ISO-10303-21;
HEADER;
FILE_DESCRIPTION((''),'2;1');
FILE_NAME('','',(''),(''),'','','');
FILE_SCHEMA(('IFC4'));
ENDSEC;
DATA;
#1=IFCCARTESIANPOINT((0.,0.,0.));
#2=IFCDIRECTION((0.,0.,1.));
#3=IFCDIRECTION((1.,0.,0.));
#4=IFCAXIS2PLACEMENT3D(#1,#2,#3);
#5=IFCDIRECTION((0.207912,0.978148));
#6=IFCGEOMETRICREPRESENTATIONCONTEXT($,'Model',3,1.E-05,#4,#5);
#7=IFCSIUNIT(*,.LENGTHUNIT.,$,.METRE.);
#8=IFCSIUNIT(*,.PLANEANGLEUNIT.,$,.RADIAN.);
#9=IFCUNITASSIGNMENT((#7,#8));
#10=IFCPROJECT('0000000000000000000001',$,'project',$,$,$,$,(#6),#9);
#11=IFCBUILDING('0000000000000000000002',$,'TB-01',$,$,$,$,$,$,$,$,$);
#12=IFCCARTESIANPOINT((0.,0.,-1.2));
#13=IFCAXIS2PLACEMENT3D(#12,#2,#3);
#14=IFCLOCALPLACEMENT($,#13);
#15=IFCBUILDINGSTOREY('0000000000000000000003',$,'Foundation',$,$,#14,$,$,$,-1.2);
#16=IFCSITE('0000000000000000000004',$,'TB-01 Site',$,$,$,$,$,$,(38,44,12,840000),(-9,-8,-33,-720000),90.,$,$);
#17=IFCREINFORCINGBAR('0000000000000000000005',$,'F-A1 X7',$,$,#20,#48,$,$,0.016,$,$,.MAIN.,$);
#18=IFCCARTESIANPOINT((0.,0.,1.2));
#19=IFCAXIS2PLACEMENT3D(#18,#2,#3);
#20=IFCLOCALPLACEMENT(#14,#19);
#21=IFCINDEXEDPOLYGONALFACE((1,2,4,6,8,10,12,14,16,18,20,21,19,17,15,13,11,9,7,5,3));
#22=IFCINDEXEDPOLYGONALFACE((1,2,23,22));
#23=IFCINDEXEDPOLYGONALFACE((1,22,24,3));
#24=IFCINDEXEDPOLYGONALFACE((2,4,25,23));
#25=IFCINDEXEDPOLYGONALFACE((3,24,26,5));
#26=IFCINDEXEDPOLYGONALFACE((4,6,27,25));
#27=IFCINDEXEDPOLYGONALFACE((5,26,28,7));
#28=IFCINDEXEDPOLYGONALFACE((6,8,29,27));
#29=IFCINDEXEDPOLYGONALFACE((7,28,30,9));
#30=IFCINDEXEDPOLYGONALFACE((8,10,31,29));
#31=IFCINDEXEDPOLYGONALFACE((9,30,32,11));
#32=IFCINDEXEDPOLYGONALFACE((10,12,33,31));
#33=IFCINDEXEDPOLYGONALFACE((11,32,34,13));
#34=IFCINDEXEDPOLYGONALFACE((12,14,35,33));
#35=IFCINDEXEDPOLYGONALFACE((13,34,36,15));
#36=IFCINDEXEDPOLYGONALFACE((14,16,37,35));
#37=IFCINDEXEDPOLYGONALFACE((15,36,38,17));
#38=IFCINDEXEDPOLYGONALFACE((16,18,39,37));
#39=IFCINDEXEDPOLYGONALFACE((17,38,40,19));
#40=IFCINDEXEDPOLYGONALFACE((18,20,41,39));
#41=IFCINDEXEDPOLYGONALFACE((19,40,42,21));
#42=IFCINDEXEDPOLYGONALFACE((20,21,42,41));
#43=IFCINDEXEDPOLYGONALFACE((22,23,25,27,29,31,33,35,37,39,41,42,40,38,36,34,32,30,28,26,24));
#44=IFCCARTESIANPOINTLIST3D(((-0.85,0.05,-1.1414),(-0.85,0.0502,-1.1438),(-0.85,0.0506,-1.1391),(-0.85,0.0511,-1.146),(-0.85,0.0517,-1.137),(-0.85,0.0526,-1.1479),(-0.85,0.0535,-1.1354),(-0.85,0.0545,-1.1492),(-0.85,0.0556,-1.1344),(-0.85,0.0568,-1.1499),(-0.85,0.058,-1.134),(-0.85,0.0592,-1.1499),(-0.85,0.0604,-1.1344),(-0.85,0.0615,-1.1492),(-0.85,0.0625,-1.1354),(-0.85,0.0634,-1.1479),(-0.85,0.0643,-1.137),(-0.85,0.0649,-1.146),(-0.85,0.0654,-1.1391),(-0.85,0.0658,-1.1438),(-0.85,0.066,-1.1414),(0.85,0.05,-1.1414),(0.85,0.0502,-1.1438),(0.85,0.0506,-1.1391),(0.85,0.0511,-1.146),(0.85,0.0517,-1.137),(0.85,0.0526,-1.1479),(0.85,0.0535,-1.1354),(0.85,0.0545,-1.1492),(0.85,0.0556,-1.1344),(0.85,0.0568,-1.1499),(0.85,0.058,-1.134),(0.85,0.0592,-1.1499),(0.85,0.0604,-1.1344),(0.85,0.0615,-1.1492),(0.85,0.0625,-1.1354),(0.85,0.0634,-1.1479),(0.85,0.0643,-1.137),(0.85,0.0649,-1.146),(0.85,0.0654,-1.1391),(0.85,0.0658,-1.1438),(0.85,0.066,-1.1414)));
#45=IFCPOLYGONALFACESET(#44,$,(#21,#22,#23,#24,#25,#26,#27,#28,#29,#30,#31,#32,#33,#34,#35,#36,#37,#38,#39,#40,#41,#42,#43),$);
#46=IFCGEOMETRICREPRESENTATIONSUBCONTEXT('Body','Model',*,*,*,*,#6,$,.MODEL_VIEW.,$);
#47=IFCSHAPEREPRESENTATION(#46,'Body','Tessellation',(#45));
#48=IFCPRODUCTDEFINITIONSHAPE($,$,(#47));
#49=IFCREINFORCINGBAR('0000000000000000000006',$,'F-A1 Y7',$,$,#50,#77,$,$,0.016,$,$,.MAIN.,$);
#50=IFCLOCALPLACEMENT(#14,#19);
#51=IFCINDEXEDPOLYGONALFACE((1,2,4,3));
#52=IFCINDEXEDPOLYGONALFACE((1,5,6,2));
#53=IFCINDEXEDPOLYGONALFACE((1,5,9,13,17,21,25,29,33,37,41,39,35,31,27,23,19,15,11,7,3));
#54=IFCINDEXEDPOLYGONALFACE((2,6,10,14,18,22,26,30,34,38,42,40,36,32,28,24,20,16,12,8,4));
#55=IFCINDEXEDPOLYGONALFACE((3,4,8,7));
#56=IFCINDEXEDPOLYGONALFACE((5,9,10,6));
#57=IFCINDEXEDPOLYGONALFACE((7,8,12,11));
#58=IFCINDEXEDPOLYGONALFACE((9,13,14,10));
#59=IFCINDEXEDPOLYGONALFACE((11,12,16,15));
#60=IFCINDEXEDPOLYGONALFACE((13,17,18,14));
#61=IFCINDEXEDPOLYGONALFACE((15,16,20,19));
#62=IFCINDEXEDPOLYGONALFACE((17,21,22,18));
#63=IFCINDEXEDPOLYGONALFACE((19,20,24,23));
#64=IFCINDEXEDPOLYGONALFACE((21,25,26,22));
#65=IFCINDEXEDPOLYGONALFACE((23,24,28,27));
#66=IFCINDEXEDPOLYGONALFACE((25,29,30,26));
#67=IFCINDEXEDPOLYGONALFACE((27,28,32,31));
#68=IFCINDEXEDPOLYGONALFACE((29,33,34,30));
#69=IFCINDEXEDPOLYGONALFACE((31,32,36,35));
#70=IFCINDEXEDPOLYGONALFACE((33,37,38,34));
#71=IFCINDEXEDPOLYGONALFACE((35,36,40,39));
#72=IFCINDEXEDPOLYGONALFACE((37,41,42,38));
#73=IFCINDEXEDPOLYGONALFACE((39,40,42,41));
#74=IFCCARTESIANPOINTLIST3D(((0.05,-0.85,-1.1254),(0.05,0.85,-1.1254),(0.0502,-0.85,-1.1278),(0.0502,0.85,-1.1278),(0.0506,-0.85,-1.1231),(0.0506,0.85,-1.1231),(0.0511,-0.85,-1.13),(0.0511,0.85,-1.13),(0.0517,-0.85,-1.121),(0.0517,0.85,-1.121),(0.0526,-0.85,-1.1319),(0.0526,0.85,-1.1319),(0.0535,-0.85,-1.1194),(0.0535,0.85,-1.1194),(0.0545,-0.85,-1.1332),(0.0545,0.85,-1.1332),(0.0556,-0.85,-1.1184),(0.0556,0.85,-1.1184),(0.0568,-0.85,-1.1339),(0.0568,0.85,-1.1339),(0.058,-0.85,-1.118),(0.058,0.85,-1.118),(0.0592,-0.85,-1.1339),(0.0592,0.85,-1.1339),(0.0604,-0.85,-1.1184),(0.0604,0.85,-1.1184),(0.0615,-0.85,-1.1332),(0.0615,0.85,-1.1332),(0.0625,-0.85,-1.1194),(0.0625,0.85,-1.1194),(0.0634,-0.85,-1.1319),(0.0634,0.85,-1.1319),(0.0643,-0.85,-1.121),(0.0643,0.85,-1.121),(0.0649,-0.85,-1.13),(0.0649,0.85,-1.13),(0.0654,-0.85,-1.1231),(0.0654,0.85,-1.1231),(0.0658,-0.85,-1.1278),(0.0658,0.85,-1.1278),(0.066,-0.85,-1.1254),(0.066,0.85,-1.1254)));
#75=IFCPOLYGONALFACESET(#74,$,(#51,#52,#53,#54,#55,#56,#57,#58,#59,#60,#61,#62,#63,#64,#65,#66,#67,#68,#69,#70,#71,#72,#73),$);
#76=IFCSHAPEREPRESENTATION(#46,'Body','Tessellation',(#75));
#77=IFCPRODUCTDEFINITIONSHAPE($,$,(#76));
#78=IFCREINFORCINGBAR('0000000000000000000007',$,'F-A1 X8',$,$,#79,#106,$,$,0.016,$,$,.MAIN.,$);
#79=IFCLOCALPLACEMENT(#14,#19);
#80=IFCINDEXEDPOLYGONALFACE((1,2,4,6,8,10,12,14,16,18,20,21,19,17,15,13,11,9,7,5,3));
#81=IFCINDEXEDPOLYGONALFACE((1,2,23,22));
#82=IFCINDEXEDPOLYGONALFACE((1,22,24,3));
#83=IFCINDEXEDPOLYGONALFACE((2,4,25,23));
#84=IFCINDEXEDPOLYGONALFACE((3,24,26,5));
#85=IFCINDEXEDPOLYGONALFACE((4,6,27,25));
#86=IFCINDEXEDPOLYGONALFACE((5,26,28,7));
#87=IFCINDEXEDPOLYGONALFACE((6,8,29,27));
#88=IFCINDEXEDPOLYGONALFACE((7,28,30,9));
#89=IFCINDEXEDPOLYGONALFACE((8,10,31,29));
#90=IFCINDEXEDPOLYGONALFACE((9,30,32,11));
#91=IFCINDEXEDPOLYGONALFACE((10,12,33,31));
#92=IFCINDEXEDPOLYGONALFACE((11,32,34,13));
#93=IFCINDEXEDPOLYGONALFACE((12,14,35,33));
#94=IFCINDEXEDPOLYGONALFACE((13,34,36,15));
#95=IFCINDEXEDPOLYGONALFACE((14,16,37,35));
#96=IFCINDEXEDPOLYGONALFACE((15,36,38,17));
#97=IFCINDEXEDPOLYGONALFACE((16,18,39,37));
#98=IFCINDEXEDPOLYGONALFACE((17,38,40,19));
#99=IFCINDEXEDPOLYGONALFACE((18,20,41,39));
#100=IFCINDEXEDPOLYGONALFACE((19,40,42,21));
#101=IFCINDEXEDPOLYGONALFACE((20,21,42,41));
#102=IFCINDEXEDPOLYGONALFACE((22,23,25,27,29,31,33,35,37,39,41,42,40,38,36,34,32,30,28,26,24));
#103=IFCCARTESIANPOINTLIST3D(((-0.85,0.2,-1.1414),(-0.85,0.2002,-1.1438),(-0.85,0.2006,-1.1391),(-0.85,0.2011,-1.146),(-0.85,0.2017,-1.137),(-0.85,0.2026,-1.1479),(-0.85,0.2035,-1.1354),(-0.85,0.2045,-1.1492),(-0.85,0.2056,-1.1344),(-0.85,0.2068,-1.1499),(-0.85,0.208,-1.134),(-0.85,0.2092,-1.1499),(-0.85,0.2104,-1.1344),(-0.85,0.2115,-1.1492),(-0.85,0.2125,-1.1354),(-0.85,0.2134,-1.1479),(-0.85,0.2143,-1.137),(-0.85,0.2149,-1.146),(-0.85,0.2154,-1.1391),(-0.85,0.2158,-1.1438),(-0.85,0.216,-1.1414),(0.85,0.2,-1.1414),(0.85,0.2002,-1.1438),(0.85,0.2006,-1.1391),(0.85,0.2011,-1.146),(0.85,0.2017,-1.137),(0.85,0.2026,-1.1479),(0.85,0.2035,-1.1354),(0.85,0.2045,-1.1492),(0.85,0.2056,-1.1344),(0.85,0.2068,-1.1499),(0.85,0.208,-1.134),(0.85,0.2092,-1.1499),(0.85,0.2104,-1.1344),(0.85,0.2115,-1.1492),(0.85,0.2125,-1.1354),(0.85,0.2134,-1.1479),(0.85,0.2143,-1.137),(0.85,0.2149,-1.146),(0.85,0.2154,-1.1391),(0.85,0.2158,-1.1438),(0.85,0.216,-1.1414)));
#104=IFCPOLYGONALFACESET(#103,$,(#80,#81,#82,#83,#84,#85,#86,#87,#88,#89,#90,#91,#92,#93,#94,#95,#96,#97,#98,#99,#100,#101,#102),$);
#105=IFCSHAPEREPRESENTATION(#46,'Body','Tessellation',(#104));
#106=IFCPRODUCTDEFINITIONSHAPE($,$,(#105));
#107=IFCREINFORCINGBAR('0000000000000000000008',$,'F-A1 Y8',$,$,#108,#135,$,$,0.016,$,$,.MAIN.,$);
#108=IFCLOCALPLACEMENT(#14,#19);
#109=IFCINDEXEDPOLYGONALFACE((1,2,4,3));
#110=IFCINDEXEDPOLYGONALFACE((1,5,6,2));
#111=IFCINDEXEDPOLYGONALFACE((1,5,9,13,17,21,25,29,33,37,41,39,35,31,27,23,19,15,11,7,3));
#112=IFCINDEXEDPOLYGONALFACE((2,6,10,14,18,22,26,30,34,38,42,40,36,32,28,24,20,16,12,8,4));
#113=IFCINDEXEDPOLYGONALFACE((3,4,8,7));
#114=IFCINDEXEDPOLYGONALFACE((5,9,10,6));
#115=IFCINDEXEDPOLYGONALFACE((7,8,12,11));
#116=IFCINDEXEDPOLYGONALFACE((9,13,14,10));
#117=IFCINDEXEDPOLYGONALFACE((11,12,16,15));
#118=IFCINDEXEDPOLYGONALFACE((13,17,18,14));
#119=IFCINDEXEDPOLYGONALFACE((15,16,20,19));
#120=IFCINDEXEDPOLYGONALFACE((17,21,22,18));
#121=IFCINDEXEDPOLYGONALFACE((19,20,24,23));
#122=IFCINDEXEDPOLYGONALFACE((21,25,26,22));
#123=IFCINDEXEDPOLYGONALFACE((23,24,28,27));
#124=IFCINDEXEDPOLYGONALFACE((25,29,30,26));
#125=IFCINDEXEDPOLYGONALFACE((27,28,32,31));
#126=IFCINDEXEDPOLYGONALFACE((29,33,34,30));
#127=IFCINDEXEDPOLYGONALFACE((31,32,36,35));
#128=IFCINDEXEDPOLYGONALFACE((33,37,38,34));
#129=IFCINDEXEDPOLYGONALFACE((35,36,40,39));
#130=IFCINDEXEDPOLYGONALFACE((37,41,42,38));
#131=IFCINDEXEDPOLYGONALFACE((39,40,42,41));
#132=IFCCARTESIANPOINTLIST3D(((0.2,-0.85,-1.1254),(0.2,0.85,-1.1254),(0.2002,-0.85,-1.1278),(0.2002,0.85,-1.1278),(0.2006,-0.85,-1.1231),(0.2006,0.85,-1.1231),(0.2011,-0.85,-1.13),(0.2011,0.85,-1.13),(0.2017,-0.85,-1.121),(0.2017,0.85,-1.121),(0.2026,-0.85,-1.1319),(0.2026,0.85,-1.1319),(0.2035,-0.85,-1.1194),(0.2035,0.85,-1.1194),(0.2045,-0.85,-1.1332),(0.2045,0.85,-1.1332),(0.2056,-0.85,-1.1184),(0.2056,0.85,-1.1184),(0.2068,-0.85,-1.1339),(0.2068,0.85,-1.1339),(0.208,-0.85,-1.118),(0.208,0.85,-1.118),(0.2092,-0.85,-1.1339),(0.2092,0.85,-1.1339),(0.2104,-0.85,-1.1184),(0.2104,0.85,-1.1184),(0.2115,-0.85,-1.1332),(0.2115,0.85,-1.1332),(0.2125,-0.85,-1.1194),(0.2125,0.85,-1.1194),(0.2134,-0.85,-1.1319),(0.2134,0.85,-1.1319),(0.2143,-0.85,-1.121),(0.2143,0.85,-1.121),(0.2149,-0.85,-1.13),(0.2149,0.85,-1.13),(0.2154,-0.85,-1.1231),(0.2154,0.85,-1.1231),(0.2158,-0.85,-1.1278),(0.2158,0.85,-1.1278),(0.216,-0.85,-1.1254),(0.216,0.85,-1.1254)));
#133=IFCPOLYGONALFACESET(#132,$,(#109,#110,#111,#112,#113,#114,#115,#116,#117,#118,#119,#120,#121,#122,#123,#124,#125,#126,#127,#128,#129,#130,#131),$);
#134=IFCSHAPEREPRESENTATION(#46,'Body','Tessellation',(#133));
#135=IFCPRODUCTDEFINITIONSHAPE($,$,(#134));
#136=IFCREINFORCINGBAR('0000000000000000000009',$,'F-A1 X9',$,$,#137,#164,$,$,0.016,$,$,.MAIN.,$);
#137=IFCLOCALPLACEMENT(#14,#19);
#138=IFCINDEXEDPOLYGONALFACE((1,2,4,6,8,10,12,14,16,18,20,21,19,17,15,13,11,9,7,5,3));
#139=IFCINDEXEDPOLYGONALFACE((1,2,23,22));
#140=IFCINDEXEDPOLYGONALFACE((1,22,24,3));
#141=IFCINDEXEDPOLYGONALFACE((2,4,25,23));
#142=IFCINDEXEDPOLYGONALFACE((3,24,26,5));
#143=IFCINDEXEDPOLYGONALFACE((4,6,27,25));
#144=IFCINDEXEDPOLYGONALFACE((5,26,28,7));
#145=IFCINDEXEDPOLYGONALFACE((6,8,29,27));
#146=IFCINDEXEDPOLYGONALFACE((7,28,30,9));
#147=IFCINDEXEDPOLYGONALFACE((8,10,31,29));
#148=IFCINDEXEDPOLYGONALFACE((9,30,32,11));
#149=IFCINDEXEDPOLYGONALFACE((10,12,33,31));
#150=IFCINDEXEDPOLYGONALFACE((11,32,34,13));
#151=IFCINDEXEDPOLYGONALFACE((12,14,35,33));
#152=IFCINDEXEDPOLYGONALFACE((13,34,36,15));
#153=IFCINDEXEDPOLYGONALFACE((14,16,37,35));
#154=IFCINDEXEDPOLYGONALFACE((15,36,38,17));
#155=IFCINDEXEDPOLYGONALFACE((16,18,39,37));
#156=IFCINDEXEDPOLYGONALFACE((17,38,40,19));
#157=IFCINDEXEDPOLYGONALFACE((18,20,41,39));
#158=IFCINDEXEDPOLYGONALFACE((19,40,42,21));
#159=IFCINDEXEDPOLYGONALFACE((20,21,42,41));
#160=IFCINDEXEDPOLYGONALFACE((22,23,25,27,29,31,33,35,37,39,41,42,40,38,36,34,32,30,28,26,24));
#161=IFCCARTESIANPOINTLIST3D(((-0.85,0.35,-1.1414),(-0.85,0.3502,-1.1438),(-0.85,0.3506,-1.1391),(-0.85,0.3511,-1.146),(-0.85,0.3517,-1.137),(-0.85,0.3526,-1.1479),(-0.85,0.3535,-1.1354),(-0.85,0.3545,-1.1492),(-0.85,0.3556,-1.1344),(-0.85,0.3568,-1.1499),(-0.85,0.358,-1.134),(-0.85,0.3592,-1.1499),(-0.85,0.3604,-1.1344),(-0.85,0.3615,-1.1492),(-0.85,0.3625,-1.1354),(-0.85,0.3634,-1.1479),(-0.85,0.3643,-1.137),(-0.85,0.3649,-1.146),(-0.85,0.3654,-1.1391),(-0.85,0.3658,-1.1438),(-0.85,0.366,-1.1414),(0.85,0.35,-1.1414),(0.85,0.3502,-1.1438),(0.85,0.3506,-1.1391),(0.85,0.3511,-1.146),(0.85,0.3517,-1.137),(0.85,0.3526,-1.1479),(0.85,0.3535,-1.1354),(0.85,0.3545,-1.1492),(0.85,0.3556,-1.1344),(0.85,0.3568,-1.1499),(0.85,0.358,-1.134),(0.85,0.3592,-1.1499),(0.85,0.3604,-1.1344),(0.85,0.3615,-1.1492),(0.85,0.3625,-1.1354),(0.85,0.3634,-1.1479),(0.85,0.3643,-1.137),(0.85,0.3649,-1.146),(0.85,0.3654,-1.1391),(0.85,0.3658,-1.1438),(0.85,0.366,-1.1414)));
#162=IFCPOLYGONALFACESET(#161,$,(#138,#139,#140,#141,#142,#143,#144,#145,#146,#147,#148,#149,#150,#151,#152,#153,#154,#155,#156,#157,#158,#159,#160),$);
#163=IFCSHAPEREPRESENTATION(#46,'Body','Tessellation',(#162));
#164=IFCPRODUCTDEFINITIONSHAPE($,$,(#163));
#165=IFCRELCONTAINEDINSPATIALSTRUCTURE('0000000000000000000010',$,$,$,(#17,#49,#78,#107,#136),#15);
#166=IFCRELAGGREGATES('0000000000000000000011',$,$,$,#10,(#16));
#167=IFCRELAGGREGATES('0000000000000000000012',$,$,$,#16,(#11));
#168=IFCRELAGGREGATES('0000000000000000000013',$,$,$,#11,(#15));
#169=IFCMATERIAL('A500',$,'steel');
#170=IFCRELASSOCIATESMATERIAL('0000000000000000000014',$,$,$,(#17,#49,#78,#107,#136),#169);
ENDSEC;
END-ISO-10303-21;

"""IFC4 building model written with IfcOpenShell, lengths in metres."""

from ifc_helpers import new_model, entity, si_unit, direction, frame, origin_with_axes, place, context, subcontext, project, spatial, material, element, save


model = new_model("IFC4")

# Units and contexts
model_context = context("Model", 3, precision=1e-05, world=origin_with_axes(), true_north=direction((0.207912, 0.978148)))
body_context = subcontext(model_context, "Body", "Model", "MODEL_VIEW")
ifc_project = project(units=[si_unit("LENGTHUNIT", "METRE"), si_unit("PLANEANGLEUNIT", "RADIAN")], contexts=[model_context])

# Site, building, storey
site = spatial("IfcSite", under=ifc_project, Name="TB-01 Site", RefLatitude=(38, 44, 12, 840000), RefLongitude=(-9, -8, -33, -720000), RefElevation=90.0)
building = spatial("IfcBuilding", under=site, Name="TB-01")
storey_placement = place(None, frame((0.0, 0.0, -1.2), z_axis=(0.0, 0.0, 1.0), x_axis=(1.0, 0.0, 0.0)))
storey = spatial("IfcBuildingStorey", under=building, at=storey_placement, Name="Foundation", Elevation=-1.2)

# Reinforcing bars
ifc_material_1 = material(Name="A500", Category="steel")
reinforcing_bar_1_placement = place(storey_placement, frame((0.0, 0.0, 1.2), z_axis=(0.0, 0.0, 1.0), x_axis=(1.0, 0.0, 0.0)))
element("IfcReinforcingBar", 1, at=reinforcing_bar_1_placement, inside=storey, material=ifc_material_1, Name="F-A1 X7", NominalDiameter=0.016, PredefinedType="MAIN", context=body_context, shape_type="AdvancedSweptSolid", body=[
    entity("IfcSweptDiskSolid", entity("IfcPolyline", [entity("IfcCartesianPoint", [-0.85, 0.058, -1.142]), entity("IfcCartesianPoint", [0.85, 0.058, -1.142])]), 0.008),
])
reinforcing_bar_2_placement = place(storey_placement, frame((0.0, 0.0, 1.2), z_axis=(0.0, 0.0, 1.0), x_axis=(1.0, 0.0, 0.0)))
element("IfcReinforcingBar", 2, at=reinforcing_bar_2_placement, inside=storey, material=ifc_material_1, Name="F-A1 Y7", NominalDiameter=0.016, PredefinedType="MAIN", context=body_context, shape_type="AdvancedSweptSolid", body=[
    entity("IfcSweptDiskSolid", entity("IfcPolyline", [entity("IfcCartesianPoint", [0.058, -0.85, -1.126]), entity("IfcCartesianPoint", [0.058, 0.85, -1.126])]), 0.008),
])
reinforcing_bar_3_placement = place(storey_placement, frame((0.0, 0.0, 1.2), z_axis=(0.0, 0.0, 1.0), x_axis=(1.0, 0.0, 0.0)))
element("IfcReinforcingBar", 3, at=reinforcing_bar_3_placement, inside=storey, material=ifc_material_1, Name="F-A1 X8", NominalDiameter=0.016, PredefinedType="MAIN", context=body_context, shape_type="AdvancedSweptSolid", body=[
    entity("IfcSweptDiskSolid", entity("IfcPolyline", [entity("IfcCartesianPoint", [-0.85, 0.208, -1.142]), entity("IfcCartesianPoint", [0.85, 0.208, -1.142])]), 0.008),
])
reinforcing_bar_4_placement = place(storey_placement, frame((0.0, 0.0, 1.2), z_axis=(0.0, 0.0, 1.0), x_axis=(1.0, 0.0, 0.0)))
element("IfcReinforcingBar", 4, at=reinforcing_bar_4_placement, inside=storey, material=ifc_material_1, Name="F-A1 Y8", NominalDiameter=0.016, PredefinedType="MAIN", context=body_context, shape_type="AdvancedSweptSolid", body=[
    entity("IfcSweptDiskSolid", entity("IfcPolyline", [entity("IfcCartesianPoint", [0.208, -0.85, -1.126]), entity("IfcCartesianPoint", [0.208, 0.85, -1.126])]), 0.008),
])
reinforcing_bar_5_placement = place(storey_placement, frame((0.0, 0.0, 1.2), z_axis=(0.0, 0.0, 1.0), x_axis=(1.0, 0.0, 0.0)))
element("IfcReinforcingBar", 5, at=reinforcing_bar_5_placement, inside=storey, material=ifc_material_1, Name="F-A1 X9", NominalDiameter=0.016, PredefinedType="MAIN", context=body_context, shape_type="AdvancedSweptSolid", body=[
    entity("IfcSweptDiskSolid", entity("IfcPolyline", [entity("IfcCartesianPoint", [-0.85, 0.358, -1.142]), entity("IfcCartesianPoint", [0.85, 0.358, -1.142])]), 0.008),
])

save(model, "model.ifc")
